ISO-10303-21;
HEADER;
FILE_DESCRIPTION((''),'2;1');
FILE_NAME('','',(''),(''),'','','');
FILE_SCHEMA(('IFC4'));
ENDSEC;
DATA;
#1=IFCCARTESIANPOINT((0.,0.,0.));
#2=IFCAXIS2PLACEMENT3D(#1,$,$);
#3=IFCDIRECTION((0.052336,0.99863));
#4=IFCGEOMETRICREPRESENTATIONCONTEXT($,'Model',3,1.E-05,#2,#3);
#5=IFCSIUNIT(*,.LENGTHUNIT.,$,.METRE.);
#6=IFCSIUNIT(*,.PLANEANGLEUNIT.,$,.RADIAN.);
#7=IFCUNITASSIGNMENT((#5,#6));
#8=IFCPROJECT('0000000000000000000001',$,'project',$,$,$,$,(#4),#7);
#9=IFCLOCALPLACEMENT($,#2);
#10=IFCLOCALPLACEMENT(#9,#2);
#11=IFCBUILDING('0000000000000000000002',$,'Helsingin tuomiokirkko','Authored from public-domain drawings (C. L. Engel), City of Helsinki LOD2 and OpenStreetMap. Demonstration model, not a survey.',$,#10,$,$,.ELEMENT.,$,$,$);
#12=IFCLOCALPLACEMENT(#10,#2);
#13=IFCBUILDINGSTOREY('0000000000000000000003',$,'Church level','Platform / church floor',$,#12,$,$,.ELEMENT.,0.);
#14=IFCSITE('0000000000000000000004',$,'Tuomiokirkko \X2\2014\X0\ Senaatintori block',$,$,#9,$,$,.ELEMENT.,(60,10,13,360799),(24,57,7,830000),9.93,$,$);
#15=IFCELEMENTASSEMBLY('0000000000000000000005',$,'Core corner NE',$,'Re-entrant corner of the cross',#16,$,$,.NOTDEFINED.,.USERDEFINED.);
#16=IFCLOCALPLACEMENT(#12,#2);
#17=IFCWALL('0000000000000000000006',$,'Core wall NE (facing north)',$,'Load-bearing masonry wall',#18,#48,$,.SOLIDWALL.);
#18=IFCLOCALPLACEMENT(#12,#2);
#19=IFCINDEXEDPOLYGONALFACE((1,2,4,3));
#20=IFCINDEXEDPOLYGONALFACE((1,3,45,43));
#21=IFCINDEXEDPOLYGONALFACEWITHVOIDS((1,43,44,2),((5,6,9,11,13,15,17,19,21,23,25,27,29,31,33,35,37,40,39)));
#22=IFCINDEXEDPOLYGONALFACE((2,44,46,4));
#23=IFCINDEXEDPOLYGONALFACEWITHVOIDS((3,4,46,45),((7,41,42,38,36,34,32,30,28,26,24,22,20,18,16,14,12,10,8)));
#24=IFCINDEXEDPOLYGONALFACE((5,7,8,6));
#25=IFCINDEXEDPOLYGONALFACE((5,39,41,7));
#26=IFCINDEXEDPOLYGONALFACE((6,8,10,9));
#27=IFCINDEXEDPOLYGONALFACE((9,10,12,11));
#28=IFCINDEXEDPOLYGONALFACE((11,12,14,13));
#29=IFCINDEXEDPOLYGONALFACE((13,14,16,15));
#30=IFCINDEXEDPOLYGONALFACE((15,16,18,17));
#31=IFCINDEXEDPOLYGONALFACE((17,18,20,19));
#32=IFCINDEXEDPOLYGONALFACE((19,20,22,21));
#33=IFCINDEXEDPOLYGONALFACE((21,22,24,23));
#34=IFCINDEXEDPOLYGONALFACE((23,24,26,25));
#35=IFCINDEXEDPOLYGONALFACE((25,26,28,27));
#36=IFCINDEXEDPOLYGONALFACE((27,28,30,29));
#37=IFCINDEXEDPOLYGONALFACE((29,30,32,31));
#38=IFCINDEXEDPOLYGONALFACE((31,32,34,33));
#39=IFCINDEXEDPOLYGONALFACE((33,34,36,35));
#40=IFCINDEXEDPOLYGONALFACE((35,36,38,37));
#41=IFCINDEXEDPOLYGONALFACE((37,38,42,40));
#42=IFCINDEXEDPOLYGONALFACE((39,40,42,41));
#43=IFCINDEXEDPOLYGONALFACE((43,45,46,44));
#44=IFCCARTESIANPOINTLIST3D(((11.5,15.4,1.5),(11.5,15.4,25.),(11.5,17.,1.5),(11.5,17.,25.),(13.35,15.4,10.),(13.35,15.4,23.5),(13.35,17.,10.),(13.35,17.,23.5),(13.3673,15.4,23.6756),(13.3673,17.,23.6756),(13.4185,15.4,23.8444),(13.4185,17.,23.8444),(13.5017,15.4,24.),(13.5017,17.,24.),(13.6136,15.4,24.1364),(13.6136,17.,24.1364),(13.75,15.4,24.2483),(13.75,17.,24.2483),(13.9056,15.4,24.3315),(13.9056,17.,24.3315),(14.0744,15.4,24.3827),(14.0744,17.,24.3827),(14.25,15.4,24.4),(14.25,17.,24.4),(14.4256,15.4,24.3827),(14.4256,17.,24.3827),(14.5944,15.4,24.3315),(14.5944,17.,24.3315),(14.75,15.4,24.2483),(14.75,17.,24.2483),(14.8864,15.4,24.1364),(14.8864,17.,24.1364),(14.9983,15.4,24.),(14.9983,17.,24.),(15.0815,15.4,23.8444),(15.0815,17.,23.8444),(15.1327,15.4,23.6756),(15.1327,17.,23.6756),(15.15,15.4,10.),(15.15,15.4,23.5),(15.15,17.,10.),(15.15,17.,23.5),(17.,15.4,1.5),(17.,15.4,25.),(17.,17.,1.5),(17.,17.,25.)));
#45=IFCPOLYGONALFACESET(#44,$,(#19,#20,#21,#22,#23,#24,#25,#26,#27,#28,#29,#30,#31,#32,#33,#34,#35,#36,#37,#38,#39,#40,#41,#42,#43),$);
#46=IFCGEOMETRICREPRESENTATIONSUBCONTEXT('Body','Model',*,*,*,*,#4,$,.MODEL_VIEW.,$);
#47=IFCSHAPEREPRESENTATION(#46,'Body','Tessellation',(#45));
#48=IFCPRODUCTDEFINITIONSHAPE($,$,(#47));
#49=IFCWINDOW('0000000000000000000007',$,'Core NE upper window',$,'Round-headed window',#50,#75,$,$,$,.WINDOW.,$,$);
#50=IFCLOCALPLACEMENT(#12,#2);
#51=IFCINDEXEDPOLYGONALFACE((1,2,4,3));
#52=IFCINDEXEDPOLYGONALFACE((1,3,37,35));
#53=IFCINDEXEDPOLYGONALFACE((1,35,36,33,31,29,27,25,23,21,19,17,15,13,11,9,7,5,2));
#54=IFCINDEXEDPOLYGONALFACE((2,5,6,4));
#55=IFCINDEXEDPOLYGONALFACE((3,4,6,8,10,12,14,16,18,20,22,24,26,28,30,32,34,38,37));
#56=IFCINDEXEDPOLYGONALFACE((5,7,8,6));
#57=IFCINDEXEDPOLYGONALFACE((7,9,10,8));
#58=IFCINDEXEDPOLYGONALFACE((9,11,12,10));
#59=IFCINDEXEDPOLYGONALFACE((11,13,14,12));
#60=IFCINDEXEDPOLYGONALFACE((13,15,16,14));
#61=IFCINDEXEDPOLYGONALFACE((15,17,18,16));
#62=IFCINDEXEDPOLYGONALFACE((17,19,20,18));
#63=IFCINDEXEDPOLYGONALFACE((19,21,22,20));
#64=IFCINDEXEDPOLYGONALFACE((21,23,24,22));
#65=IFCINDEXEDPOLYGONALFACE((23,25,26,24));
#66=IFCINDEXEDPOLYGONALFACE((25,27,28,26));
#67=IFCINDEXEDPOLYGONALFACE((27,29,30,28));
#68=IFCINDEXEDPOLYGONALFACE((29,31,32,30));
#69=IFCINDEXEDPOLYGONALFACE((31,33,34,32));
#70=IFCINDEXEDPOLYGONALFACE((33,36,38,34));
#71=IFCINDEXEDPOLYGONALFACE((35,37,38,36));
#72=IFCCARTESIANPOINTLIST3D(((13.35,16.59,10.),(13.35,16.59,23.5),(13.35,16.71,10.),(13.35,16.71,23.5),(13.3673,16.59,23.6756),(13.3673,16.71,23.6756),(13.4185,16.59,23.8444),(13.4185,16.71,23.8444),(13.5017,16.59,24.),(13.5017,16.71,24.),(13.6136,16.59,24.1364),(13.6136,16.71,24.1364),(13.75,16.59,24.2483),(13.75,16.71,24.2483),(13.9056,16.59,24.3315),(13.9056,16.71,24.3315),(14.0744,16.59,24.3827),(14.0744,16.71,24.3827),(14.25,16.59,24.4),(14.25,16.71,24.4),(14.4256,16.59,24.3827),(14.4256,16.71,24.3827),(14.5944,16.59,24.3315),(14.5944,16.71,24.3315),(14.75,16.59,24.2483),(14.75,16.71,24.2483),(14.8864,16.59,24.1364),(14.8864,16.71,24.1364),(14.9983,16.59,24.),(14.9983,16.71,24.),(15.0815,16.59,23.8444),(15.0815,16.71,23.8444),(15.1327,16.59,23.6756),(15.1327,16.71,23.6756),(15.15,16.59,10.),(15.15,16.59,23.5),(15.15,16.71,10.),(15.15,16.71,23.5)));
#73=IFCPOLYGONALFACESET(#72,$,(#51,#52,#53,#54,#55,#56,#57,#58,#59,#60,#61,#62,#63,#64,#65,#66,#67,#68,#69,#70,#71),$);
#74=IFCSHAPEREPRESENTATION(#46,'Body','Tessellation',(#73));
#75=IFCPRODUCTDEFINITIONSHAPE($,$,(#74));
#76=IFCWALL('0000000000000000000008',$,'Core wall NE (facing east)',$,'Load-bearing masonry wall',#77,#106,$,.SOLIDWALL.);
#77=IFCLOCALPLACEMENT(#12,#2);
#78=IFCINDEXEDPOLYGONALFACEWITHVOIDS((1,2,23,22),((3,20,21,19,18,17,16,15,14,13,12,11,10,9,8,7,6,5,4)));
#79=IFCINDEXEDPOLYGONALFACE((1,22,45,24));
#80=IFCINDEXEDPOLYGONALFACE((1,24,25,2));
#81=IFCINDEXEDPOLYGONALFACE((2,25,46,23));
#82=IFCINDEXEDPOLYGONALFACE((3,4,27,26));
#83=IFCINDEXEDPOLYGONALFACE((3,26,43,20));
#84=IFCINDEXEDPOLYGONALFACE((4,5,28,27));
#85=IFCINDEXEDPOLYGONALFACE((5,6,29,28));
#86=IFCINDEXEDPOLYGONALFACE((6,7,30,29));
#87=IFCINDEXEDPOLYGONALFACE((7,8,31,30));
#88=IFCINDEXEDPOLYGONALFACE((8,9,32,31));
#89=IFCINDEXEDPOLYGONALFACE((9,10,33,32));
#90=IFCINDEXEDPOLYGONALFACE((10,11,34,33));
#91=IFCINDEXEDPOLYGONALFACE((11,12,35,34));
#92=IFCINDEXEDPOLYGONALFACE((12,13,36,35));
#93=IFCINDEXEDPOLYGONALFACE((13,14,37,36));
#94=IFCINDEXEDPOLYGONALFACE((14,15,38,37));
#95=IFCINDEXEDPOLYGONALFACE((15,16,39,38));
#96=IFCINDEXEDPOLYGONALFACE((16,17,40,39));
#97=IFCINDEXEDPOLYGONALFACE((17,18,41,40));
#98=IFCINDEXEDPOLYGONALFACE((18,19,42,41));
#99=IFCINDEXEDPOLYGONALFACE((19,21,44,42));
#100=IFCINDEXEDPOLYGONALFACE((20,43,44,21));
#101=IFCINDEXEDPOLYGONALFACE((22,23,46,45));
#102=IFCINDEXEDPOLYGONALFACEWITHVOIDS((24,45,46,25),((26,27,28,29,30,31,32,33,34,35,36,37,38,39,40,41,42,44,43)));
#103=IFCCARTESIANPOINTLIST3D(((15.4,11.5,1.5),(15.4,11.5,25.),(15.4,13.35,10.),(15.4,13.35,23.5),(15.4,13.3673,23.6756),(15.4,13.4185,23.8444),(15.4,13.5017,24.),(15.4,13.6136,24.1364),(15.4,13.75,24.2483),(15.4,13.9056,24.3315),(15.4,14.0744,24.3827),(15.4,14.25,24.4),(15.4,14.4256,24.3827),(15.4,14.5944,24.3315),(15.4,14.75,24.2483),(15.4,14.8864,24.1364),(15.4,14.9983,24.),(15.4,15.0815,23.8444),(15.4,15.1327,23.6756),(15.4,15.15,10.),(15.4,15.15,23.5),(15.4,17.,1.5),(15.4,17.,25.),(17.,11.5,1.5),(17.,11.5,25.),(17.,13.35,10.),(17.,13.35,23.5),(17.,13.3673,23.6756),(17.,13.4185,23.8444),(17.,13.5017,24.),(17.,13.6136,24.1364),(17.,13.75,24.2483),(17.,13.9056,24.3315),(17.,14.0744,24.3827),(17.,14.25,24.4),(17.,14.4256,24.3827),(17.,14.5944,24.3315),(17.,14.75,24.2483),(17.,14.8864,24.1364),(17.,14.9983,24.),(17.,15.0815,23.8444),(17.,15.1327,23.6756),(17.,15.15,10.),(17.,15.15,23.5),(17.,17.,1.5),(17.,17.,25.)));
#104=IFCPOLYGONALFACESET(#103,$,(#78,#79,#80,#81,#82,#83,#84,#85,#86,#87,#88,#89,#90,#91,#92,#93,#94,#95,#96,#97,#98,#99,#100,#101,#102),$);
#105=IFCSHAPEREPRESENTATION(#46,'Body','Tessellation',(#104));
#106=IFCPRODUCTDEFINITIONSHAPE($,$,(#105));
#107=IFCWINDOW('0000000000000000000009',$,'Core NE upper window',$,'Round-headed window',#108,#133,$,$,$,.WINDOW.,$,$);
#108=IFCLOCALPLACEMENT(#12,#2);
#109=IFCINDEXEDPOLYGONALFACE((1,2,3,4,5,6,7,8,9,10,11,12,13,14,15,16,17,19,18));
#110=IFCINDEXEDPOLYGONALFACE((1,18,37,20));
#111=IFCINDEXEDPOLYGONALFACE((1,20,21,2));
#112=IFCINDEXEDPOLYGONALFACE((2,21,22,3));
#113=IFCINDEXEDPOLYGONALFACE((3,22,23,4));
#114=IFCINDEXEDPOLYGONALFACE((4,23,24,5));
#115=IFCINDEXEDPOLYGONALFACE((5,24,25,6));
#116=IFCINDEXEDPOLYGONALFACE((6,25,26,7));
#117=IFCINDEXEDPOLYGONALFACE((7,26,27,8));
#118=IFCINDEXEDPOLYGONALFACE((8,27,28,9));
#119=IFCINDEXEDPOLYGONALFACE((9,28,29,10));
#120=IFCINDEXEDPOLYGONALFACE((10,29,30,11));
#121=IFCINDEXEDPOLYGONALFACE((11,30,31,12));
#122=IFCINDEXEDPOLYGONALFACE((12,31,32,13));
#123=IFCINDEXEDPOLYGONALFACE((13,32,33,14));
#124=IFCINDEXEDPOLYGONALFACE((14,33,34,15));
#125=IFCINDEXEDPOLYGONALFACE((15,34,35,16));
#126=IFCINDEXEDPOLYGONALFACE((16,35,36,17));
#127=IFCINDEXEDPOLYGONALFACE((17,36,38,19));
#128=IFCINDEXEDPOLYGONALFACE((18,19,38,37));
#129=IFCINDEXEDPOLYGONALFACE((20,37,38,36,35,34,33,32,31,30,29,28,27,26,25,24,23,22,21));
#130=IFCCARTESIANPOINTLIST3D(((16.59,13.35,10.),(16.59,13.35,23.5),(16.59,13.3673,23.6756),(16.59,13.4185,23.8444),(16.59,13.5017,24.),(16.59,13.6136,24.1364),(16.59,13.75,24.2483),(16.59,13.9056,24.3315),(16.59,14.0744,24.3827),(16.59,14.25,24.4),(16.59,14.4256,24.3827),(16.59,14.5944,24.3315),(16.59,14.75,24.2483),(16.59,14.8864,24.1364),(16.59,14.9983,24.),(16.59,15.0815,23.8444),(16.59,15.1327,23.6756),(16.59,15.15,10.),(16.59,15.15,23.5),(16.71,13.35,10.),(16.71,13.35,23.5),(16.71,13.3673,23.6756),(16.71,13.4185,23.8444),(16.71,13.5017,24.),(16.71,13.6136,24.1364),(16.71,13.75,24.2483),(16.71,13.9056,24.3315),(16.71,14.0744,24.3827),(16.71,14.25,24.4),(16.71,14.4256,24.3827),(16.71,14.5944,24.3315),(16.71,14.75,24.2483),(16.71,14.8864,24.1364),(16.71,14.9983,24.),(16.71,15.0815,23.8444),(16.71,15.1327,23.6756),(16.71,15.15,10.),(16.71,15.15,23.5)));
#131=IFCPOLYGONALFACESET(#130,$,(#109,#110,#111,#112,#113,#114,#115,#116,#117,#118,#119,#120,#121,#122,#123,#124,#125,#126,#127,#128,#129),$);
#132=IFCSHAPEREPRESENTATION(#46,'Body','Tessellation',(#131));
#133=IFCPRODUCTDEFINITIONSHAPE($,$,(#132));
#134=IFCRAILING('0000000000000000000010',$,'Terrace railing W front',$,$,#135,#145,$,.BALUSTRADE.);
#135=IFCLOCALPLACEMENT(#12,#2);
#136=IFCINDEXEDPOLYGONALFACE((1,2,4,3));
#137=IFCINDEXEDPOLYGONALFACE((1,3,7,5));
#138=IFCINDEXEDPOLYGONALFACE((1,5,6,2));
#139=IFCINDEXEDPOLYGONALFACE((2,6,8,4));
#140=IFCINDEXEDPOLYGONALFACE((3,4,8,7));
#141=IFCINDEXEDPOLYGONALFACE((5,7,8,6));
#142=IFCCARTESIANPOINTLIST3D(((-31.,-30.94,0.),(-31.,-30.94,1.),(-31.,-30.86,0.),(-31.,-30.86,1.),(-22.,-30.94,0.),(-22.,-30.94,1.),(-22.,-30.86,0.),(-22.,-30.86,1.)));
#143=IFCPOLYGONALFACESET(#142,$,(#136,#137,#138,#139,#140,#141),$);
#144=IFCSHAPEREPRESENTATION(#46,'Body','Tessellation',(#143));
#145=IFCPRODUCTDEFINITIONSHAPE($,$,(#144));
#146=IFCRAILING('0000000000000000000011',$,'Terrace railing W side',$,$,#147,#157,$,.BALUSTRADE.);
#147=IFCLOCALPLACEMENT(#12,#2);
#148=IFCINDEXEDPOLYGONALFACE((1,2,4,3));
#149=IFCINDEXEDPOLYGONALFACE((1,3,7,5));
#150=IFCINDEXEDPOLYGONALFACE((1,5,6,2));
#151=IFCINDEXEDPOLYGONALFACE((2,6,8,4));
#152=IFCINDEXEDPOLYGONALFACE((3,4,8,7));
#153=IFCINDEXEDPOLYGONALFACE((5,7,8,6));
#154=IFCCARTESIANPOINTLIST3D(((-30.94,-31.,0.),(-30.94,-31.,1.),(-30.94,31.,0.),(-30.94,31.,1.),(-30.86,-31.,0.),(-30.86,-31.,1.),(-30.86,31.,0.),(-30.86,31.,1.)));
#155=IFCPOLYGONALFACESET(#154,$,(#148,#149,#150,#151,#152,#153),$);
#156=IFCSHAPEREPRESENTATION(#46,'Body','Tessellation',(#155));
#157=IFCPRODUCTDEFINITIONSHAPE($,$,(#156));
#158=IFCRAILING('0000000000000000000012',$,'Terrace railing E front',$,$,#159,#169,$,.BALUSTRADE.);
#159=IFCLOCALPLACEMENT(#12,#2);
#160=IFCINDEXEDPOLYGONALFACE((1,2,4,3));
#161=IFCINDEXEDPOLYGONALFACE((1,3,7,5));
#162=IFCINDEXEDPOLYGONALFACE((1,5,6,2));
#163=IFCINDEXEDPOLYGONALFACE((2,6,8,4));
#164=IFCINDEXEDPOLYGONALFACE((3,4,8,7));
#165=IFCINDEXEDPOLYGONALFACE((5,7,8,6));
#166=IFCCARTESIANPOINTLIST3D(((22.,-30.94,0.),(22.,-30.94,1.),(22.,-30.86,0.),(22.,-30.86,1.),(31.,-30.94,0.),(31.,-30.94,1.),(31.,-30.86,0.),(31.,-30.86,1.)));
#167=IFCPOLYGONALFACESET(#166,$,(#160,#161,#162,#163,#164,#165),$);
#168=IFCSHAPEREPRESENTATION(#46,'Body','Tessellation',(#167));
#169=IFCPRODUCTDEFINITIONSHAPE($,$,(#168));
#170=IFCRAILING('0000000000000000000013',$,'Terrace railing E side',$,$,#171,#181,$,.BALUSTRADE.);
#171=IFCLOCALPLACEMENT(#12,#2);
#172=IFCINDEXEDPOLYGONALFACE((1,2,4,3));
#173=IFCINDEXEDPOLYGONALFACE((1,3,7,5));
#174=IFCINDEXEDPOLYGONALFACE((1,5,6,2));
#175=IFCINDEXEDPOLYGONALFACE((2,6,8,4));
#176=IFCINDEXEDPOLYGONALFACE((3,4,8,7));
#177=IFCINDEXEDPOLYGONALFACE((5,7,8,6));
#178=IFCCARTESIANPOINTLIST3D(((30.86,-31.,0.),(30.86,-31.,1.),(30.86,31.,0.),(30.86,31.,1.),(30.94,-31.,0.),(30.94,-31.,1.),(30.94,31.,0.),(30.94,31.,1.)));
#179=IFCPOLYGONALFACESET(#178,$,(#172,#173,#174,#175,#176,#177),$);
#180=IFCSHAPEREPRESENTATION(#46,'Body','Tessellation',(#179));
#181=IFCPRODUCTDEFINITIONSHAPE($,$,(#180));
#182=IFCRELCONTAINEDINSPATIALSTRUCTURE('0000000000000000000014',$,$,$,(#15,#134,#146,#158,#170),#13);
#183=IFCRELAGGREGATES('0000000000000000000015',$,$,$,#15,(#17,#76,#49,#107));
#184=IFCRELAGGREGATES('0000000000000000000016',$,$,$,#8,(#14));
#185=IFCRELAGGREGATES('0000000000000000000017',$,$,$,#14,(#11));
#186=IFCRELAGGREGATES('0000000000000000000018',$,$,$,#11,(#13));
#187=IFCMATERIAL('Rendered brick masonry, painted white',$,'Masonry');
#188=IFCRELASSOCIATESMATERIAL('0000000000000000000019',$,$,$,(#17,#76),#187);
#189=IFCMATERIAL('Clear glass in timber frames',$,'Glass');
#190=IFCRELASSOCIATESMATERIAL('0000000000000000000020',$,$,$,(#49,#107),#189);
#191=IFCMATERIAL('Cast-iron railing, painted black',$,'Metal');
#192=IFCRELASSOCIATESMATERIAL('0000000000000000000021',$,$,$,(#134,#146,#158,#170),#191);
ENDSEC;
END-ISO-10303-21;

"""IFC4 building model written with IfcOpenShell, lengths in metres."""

from ifc_helpers import new_model, si_unit, direction, frame, frame_2d, origin, origin_2d_with_axis, place, context, subcontext, project, spatial, polyline, rectangle, outline, extrude, material, element, fill, aggregate, save


model = new_model("IFC4")

# Units and contexts
model_context = context("Model", 3, precision=1e-05, world=origin(), true_north=direction((0.052336, 0.99863)))
body_context = subcontext(model_context, "Body", "Model", "MODEL_VIEW")
ifc_project = project(units=[si_unit("LENGTHUNIT", "METRE"), si_unit("PLANEANGLEUNIT", "RADIAN")], contexts=[model_context])

# Site, building, storey
site_placement = place(None, origin())
site = spatial("IfcSite", under=ifc_project, at=site_placement, Name="Tuomiokirkko — Senaatintori block", CompositionType="ELEMENT", RefLatitude=(60, 10, 13, 360799), RefLongitude=(24, 57, 7, 830000), RefElevation=9.93)
building_placement = place(site_placement, origin())
building = spatial("IfcBuilding", under=site, at=building_placement, Name="Helsingin tuomiokirkko", Description="Authored from public-domain drawings (C. L. Engel), City of Helsinki LOD2 and OpenStreetMap. Demonstration model, not a survey.", CompositionType="ELEMENT")
storey_placement = place(building_placement, origin())
storey = spatial("IfcBuildingStorey", under=building, at=storey_placement, Name="Church level", Description="Platform / church floor", CompositionType="ELEMENT", Elevation=0.0)

# Element assembly, walls, openings, windows
ifc_material_1 = material(Name="Rendered brick masonry, painted white", Category="Masonry")
ifc_material_2 = material(Name="Clear glass in timber frames", Category="Glass")
assembly_1_placement = place(building_placement, origin())
assembly_1 = element("IfcElementAssembly", 1, at=assembly_1_placement, inside=storey, Name="Core corner NE", ObjectType="Re-entrant corner of the cross", AssemblyPlace="NOTDEFINED", PredefinedType="USERDEFINED")
wall_1_placement = place(building_placement, origin())
wall_1 = element("IfcWall", 2, at=wall_1_placement, material=ifc_material_1, Name="Core wall NE (facing north)", ObjectType="Load-bearing masonry wall", PredefinedType="SOLIDWALL", context=body_context, shape_type="SweptSolid", body=[
    extrude(rectangle(XDim=5.5, YDim=1.6, at=origin_2d_with_axis()), frame((14.25, 16.2, 1.5)), (0.0, 0.0, 1.0), 23.5),
])
opening_1_placement = place(building_placement, origin())
opening_1 = element("IfcOpeningElement", 3, at=opening_1_placement, cuts=wall_1, PredefinedType="OPENING", context=body_context, shape_type="SweptSolid", body=[
    extrude(outline(polyline([(-0.9, 0.0), (0.9, 0.0), (0.9, 13.5), (0.8827, 13.6756), (0.8315, 13.8444), (0.7483, 14.0), (0.6364, 14.1364), (0.5, 14.2483), (0.3444, 14.3315), (0.1756, 14.3827), (0.0, 14.4), (-0.1756, 14.3827), (-0.3444, 14.3315), (-0.5, 14.2483), (-0.6364, 14.1364), (-0.7483, 14.0), (-0.8315, 13.8444), (-0.8827, 13.6756), (-0.9, 13.5), (-0.9, 0.0)])), frame((14.25, 17.2, 10.0), z_axis=(0.0, -1.0, 0.0), x_axis=(1.0, 0.0, 0.0)), (0.0, 0.0, 1.0), 2.0),
])
window_1_placement = place(building_placement, origin())
window_1 = element("IfcWindow", 4, at=window_1_placement, material=ifc_material_2, Name="Core NE upper window", ObjectType="Round-headed window", PredefinedType="WINDOW", context=body_context, shape_type="SweptSolid", body=[
    extrude(outline(polyline([(-0.9, 0.0), (0.9, 0.0), (0.9, 13.5), (0.8827, 13.6756), (0.8315, 13.8444), (0.7483, 14.0), (0.6364, 14.1364), (0.5, 14.2483), (0.3444, 14.3315), (0.1756, 14.3827), (0.0, 14.4), (-0.1756, 14.3827), (-0.3444, 14.3315), (-0.5, 14.2483), (-0.6364, 14.1364), (-0.7483, 14.0), (-0.8315, 13.8444), (-0.8827, 13.6756), (-0.9, 13.5), (-0.9, 0.0)])), frame((14.25, 16.71, 10.0), z_axis=(0.0, -1.0, 0.0), x_axis=(1.0, 0.0, 0.0)), (0.0, 0.0, 1.0), 0.12),
])
fill(opening_1, window_1)
wall_2_placement = place(building_placement, origin())
wall_2 = element("IfcWall", 5, at=wall_2_placement, material=ifc_material_1, Name="Core wall NE (facing east)", ObjectType="Load-bearing masonry wall", PredefinedType="SOLIDWALL", context=body_context, shape_type="SweptSolid", body=[
    extrude(rectangle(XDim=5.5, YDim=1.6, at=frame_2d((0.0, 0.0), x_axis=(0.0, 1.0))), frame((16.2, 14.25, 1.5)), (0.0, 0.0, 1.0), 23.5),
])
opening_2_placement = place(building_placement, origin())
opening_2 = element("IfcOpeningElement", 6, at=opening_2_placement, cuts=wall_2, PredefinedType="OPENING", context=body_context, shape_type="SweptSolid", body=[
    extrude(outline(polyline([(-0.9, 0.0), (0.9, 0.0), (0.9, 13.5), (0.8827, 13.6756), (0.8315, 13.8444), (0.7483, 14.0), (0.6364, 14.1364), (0.5, 14.2483), (0.3444, 14.3315), (0.1756, 14.3827), (0.0, 14.4), (-0.1756, 14.3827), (-0.3444, 14.3315), (-0.5, 14.2483), (-0.6364, 14.1364), (-0.7483, 14.0), (-0.8315, 13.8444), (-0.8827, 13.6756), (-0.9, 13.5), (-0.9, 0.0)])), frame((15.2, 14.25, 10.0), z_axis=(1.0, 0.0, 0.0), x_axis=(0.0, 1.0, 0.0)), (0.0, 0.0, 1.0), 2.0),
])
window_2_placement = place(building_placement, origin())
window_2 = element("IfcWindow", 7, at=window_2_placement, material=ifc_material_2, Name="Core NE upper window", ObjectType="Round-headed window", PredefinedType="WINDOW", context=body_context, shape_type="SweptSolid", body=[
    extrude(outline(polyline([(-0.9, 0.0), (0.9, 0.0), (0.9, 13.5), (0.8827, 13.6756), (0.8315, 13.8444), (0.7483, 14.0), (0.6364, 14.1364), (0.5, 14.2483), (0.3444, 14.3315), (0.1756, 14.3827), (0.0, 14.4), (-0.1756, 14.3827), (-0.3444, 14.3315), (-0.5, 14.2483), (-0.6364, 14.1364), (-0.7483, 14.0), (-0.8315, 13.8444), (-0.8827, 13.6756), (-0.9, 13.5), (-0.9, 0.0)])), frame((16.59, 14.25, 10.0), z_axis=(1.0, 0.0, 0.0), x_axis=(0.0, 1.0, 0.0)), (0.0, 0.0, 1.0), 0.12),
])
fill(opening_2, window_2)
aggregate(assembly_1, [wall_1, wall_2, window_1, window_2])

# Railings
ifc_material_3 = material(Name="Cast-iron railing, painted black", Category="Metal")
railing_1_placement = place(building_placement, origin())
element("IfcRailing", 8, at=railing_1_placement, inside=storey, material=ifc_material_3, Name="Terrace railing W front", PredefinedType="BALUSTRADE", context=body_context, shape_type="SweptSolid", body=[
    extrude(rectangle(XDim=9.0, YDim=0.08, at=origin_2d_with_axis()), frame((-26.5, -30.9, 0.0)), (0.0, 0.0, 1.0), 1.0),
])
railing_2_placement = place(building_placement, origin())
element("IfcRailing", 9, at=railing_2_placement, inside=storey, material=ifc_material_3, Name="Terrace railing W side", PredefinedType="BALUSTRADE", context=body_context, shape_type="SweptSolid", body=[
    extrude(rectangle(XDim=0.08, YDim=62.0, at=origin_2d_with_axis()), frame((-30.9, 0.0, 0.0)), (0.0, 0.0, 1.0), 1.0),
])
railing_3_placement = place(building_placement, origin())
element("IfcRailing", 10, at=railing_3_placement, inside=storey, material=ifc_material_3, Name="Terrace railing E front", PredefinedType="BALUSTRADE", context=body_context, shape_type="SweptSolid", body=[
    extrude(rectangle(XDim=9.0, YDim=0.08, at=origin_2d_with_axis()), frame((26.5, -30.9, 0.0)), (0.0, 0.0, 1.0), 1.0),
])
railing_4_placement = place(building_placement, origin())
element("IfcRailing", 11, at=railing_4_placement, inside=storey, material=ifc_material_3, Name="Terrace railing E side", PredefinedType="BALUSTRADE", context=body_context, shape_type="SweptSolid", body=[
    extrude(rectangle(XDim=0.08, YDim=62.0, at=origin_2d_with_axis()), frame((30.9, 0.0, 0.0)), (0.0, 0.0, 1.0), 1.0),
])

save(model, "model.ifc")
